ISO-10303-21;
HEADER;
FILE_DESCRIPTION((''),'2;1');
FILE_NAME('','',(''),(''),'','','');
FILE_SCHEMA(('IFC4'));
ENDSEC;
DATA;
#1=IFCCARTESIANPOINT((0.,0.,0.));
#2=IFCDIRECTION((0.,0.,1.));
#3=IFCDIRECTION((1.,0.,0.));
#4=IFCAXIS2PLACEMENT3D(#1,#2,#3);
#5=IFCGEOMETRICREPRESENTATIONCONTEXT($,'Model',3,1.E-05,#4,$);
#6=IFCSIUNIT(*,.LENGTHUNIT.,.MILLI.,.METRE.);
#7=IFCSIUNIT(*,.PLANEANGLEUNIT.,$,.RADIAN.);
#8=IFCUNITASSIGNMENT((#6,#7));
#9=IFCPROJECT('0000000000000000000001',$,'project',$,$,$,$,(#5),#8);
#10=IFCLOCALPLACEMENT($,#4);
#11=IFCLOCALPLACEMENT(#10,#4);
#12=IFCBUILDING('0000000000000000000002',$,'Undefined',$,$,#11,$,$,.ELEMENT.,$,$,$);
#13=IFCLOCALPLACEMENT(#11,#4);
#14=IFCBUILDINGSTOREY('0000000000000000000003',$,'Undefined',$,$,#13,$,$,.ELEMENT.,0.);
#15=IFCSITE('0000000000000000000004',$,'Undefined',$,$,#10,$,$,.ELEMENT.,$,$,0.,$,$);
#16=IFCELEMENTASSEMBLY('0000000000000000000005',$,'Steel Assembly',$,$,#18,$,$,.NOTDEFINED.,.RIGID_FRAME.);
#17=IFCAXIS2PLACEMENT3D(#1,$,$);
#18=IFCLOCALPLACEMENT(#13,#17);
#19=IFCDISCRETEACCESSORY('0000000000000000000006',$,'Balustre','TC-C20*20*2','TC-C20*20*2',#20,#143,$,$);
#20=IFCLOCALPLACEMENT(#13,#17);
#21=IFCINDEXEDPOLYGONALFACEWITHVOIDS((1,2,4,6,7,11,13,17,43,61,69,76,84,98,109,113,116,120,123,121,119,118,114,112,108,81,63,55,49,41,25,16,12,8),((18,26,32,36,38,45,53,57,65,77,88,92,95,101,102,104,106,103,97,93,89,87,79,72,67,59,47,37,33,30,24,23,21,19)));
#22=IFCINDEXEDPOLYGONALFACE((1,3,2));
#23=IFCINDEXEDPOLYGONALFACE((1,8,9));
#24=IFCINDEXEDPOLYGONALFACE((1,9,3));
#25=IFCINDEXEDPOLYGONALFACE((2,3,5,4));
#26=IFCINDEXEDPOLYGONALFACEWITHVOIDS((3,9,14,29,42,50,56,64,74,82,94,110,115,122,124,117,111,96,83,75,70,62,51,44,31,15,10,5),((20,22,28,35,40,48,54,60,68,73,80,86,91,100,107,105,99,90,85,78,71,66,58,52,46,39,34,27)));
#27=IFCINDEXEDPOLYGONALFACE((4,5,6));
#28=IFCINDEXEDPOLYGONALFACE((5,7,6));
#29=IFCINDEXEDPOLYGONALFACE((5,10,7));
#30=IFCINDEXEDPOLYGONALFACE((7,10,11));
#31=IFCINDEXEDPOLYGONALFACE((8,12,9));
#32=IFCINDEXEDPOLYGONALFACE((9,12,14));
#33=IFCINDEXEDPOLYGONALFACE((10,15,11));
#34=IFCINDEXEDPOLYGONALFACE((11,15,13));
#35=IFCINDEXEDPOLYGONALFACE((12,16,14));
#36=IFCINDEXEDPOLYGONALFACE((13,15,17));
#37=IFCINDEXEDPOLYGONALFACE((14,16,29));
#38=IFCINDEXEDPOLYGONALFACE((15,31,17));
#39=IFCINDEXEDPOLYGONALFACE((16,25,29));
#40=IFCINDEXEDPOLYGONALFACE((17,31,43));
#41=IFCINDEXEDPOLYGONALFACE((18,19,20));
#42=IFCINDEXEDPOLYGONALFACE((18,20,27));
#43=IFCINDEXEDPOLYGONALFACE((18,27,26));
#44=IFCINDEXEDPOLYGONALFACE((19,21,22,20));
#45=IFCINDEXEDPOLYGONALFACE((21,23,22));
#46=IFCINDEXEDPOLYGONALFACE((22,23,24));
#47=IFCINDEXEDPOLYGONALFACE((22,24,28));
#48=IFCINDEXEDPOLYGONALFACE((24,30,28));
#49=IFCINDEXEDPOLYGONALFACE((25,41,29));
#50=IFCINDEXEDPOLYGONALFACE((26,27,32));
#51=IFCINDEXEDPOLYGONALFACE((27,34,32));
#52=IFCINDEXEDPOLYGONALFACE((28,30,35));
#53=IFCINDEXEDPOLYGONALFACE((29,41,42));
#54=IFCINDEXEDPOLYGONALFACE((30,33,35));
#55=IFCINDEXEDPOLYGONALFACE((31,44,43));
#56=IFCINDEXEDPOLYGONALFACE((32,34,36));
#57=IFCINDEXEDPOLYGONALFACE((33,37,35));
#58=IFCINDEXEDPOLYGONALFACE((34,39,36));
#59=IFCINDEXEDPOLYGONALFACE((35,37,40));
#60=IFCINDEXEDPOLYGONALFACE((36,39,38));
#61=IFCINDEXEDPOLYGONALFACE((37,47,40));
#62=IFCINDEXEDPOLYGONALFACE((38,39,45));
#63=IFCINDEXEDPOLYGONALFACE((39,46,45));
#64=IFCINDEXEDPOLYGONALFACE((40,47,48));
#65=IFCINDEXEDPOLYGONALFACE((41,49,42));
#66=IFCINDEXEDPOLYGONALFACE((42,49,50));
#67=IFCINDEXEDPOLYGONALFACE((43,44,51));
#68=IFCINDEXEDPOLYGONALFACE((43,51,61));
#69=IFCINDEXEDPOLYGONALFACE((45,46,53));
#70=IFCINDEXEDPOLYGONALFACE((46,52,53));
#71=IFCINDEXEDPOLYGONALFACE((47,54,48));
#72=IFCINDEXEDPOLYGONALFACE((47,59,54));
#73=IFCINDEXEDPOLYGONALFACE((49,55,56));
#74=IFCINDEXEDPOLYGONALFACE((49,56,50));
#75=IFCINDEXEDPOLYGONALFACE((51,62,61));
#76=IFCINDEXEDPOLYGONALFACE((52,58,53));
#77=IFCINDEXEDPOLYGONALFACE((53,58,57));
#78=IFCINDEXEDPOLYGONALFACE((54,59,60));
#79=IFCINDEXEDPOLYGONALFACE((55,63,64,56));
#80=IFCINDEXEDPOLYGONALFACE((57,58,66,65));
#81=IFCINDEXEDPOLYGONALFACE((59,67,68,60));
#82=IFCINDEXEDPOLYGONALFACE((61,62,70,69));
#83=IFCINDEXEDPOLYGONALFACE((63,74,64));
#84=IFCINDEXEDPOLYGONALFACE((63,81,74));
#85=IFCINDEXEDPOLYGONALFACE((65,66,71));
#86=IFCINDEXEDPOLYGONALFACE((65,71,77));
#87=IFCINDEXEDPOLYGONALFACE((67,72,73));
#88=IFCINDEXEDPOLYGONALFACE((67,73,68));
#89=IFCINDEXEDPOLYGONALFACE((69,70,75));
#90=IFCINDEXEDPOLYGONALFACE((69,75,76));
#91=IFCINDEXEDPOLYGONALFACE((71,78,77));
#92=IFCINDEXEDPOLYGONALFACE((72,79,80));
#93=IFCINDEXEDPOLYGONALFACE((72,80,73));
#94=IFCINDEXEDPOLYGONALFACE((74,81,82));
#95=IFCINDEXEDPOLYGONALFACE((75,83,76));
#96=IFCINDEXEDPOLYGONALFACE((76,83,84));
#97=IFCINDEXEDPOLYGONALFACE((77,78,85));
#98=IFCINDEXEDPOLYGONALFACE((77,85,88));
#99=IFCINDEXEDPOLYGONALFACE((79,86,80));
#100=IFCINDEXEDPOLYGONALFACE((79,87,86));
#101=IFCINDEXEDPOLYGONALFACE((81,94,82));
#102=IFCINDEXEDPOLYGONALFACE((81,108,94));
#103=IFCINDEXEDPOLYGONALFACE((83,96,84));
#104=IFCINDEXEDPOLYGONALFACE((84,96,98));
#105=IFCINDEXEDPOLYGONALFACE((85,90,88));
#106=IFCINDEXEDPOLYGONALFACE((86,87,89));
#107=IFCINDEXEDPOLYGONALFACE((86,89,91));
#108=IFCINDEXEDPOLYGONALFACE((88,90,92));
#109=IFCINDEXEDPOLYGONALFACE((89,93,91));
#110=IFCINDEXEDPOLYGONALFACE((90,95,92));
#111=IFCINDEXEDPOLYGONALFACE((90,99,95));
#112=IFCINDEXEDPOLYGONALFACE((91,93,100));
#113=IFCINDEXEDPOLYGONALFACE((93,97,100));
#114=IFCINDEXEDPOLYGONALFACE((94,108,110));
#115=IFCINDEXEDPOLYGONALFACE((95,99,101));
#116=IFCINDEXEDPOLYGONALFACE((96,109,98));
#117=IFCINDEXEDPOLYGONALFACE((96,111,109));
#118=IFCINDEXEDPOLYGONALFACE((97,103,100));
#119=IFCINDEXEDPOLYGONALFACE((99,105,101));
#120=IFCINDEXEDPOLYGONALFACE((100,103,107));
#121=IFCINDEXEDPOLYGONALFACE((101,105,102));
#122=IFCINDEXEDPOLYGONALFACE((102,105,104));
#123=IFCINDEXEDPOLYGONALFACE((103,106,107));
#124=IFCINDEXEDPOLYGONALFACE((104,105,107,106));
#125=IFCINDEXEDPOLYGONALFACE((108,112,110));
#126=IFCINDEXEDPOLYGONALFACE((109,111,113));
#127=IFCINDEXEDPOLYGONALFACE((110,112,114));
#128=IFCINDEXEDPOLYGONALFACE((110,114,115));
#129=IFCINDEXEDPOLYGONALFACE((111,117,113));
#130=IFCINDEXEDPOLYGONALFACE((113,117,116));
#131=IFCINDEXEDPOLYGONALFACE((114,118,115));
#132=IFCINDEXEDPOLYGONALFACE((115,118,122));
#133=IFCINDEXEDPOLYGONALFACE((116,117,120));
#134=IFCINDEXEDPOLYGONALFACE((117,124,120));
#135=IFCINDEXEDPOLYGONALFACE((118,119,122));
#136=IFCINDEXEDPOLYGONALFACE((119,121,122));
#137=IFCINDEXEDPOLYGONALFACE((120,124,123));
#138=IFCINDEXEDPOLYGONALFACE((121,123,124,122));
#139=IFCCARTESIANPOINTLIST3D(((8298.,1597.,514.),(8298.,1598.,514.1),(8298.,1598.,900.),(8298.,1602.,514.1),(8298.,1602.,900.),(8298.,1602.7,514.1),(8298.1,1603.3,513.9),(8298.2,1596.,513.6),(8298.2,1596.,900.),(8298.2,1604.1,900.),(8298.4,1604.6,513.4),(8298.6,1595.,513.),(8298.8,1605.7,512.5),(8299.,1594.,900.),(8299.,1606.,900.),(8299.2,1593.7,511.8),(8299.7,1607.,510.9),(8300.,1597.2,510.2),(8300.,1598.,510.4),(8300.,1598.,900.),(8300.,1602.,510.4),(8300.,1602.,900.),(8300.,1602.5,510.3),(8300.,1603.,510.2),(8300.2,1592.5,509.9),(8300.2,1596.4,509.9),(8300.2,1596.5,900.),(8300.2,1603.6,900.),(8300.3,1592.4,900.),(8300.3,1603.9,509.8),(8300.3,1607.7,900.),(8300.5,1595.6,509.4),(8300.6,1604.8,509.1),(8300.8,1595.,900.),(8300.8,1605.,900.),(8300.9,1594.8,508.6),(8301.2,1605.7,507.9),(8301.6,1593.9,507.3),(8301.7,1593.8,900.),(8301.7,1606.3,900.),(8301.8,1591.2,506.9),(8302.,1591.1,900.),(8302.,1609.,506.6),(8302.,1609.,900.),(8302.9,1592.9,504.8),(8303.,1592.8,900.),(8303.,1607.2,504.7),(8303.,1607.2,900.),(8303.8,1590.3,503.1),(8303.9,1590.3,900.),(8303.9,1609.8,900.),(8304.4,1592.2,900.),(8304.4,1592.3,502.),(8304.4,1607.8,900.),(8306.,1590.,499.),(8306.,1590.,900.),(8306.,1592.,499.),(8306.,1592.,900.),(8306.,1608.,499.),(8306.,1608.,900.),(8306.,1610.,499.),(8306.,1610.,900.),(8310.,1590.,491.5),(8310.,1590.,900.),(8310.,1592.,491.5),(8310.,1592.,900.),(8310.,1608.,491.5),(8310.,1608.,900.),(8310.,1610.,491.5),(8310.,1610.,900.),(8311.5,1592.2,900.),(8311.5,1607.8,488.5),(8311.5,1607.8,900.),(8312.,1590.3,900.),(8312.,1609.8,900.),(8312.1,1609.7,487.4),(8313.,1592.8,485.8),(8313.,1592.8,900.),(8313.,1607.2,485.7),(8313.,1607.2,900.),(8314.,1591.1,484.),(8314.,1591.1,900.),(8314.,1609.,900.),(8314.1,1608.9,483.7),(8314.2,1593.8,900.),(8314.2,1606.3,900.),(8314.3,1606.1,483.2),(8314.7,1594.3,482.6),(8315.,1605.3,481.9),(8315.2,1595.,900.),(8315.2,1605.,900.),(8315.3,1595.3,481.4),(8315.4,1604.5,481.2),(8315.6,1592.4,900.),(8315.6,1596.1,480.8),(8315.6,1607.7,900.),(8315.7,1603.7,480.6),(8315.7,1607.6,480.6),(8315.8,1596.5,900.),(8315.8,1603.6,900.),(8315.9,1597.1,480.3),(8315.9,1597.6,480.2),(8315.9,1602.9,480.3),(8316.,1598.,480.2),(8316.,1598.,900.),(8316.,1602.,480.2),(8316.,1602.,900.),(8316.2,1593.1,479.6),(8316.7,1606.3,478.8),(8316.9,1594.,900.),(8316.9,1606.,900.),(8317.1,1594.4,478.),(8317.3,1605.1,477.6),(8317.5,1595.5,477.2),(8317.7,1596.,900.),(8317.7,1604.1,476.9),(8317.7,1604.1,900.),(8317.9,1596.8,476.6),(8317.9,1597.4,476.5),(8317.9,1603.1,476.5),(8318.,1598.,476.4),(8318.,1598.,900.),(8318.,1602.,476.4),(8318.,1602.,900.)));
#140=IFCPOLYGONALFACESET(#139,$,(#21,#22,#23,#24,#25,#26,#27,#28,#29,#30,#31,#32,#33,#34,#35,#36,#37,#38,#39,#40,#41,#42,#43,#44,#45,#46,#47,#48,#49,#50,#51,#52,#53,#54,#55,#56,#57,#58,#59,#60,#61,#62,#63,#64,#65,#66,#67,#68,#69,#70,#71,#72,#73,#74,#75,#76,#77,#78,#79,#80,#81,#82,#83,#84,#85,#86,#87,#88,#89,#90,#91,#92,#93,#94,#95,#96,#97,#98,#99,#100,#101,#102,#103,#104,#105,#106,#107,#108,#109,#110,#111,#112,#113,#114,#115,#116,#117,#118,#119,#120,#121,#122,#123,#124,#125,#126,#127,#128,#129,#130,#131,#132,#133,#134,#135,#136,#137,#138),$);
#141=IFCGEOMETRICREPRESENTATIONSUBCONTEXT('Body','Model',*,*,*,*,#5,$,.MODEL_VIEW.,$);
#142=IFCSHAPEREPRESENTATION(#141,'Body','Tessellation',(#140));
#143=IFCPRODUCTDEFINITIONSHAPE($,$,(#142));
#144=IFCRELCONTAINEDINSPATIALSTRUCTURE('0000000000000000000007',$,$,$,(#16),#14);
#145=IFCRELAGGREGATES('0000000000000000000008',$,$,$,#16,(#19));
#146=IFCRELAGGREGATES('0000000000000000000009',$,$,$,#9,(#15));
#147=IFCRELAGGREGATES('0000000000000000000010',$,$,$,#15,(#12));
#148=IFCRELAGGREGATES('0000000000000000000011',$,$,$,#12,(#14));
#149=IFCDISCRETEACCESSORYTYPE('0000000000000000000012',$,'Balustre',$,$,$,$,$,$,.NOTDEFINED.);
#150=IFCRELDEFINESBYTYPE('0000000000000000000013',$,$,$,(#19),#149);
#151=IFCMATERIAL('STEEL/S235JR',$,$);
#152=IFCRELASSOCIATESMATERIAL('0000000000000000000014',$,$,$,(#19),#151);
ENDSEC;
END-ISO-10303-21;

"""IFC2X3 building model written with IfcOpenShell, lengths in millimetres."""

from ifc_helpers import new_model, si_unit, frame, origin_with_axes, origin_2d_with_axis, place, context, subcontext, project, spatial, hollow_rectangle, extrude, clip, halfspace, material, type_object, element, aggregate, save


model = new_model("IFC2X3")

# Units and contexts
model_context = context("Model", 3, precision=1e-05, world=origin_with_axes())
body_context = subcontext(model_context, "Body", "Model", "MODEL_VIEW")
ifc_project = project(units=[si_unit("LENGTHUNIT", "METRE", prefix="MILLI"), si_unit("PLANEANGLEUNIT", "RADIAN")], contexts=[model_context])

# Site, building, storey
site_placement = place(None, origin_with_axes())
site = spatial("IfcSite", under=ifc_project, at=site_placement, Name="Undefined", CompositionType="ELEMENT", RefElevation=0.0)
building_placement = place(site_placement, origin_with_axes())
building = spatial("IfcBuilding", under=site, at=building_placement, Name="Undefined", CompositionType="ELEMENT")
storey_placement = place(building_placement, origin_with_axes())
storey = spatial("IfcBuildingStorey", under=building, at=storey_placement, Name="Undefined", CompositionType="ELEMENT", Elevation=0.0)

# Shared definitions
ifc_material = material(Name="STEEL/S235JR")

# Element assembly, discrete accessory
discrete_accessory_type_1 = type_object("IfcDiscreteAccessoryType", Name="Balustre")
assembly_1_placement = place(storey_placement, origin_with_axes())
assembly_1 = element("IfcElementAssembly", 1, at=assembly_1_placement, inside=storey, Name="Steel Assembly", AssemblyPlace="NOTDEFINED", PredefinedType="RIGID_FRAME")
discrete_accessory_1_placement = place(assembly_1_placement, frame((8308.0, 1600.0, 900.0), z_axis=(0.0, 1.0, 0.0), x_axis=(0.0, 0.0, -1.0)))
discrete_accessory_1 = element("IfcDiscreteAccessory", 2, at=discrete_accessory_1_placement, type_object=discrete_accessory_type_1, material=ifc_material, Name="Balustre", Description="TC-C20*20*2", ObjectType="TC-C20*20*2", context=body_context, shape_type="Clipping", body=[
    clip(extrude(hollow_rectangle(XDim=20.0, YDim=20.0, WallThickness=2.0, InnerFilletRadius=6.0, OuterFilletRadius=8.0, at=origin_2d_with_axis()), frame((423.8, 0.0, 0.0), z_axis=(-1.0, 0.0, 0.0), x_axis=(0.0, -1.0, 0.0)), (0.0, 0.0, 1.0), 423.8), halfspace(frame((285.4, 63.3, 0.0), z_axis=(-0.46842, -0.883506, 0.000005), x_axis=(0.0, 0.000005, 1.0)), True)),
])

aggregate(assembly_1, [discrete_accessory_1])

save(model, "model.ifc")
